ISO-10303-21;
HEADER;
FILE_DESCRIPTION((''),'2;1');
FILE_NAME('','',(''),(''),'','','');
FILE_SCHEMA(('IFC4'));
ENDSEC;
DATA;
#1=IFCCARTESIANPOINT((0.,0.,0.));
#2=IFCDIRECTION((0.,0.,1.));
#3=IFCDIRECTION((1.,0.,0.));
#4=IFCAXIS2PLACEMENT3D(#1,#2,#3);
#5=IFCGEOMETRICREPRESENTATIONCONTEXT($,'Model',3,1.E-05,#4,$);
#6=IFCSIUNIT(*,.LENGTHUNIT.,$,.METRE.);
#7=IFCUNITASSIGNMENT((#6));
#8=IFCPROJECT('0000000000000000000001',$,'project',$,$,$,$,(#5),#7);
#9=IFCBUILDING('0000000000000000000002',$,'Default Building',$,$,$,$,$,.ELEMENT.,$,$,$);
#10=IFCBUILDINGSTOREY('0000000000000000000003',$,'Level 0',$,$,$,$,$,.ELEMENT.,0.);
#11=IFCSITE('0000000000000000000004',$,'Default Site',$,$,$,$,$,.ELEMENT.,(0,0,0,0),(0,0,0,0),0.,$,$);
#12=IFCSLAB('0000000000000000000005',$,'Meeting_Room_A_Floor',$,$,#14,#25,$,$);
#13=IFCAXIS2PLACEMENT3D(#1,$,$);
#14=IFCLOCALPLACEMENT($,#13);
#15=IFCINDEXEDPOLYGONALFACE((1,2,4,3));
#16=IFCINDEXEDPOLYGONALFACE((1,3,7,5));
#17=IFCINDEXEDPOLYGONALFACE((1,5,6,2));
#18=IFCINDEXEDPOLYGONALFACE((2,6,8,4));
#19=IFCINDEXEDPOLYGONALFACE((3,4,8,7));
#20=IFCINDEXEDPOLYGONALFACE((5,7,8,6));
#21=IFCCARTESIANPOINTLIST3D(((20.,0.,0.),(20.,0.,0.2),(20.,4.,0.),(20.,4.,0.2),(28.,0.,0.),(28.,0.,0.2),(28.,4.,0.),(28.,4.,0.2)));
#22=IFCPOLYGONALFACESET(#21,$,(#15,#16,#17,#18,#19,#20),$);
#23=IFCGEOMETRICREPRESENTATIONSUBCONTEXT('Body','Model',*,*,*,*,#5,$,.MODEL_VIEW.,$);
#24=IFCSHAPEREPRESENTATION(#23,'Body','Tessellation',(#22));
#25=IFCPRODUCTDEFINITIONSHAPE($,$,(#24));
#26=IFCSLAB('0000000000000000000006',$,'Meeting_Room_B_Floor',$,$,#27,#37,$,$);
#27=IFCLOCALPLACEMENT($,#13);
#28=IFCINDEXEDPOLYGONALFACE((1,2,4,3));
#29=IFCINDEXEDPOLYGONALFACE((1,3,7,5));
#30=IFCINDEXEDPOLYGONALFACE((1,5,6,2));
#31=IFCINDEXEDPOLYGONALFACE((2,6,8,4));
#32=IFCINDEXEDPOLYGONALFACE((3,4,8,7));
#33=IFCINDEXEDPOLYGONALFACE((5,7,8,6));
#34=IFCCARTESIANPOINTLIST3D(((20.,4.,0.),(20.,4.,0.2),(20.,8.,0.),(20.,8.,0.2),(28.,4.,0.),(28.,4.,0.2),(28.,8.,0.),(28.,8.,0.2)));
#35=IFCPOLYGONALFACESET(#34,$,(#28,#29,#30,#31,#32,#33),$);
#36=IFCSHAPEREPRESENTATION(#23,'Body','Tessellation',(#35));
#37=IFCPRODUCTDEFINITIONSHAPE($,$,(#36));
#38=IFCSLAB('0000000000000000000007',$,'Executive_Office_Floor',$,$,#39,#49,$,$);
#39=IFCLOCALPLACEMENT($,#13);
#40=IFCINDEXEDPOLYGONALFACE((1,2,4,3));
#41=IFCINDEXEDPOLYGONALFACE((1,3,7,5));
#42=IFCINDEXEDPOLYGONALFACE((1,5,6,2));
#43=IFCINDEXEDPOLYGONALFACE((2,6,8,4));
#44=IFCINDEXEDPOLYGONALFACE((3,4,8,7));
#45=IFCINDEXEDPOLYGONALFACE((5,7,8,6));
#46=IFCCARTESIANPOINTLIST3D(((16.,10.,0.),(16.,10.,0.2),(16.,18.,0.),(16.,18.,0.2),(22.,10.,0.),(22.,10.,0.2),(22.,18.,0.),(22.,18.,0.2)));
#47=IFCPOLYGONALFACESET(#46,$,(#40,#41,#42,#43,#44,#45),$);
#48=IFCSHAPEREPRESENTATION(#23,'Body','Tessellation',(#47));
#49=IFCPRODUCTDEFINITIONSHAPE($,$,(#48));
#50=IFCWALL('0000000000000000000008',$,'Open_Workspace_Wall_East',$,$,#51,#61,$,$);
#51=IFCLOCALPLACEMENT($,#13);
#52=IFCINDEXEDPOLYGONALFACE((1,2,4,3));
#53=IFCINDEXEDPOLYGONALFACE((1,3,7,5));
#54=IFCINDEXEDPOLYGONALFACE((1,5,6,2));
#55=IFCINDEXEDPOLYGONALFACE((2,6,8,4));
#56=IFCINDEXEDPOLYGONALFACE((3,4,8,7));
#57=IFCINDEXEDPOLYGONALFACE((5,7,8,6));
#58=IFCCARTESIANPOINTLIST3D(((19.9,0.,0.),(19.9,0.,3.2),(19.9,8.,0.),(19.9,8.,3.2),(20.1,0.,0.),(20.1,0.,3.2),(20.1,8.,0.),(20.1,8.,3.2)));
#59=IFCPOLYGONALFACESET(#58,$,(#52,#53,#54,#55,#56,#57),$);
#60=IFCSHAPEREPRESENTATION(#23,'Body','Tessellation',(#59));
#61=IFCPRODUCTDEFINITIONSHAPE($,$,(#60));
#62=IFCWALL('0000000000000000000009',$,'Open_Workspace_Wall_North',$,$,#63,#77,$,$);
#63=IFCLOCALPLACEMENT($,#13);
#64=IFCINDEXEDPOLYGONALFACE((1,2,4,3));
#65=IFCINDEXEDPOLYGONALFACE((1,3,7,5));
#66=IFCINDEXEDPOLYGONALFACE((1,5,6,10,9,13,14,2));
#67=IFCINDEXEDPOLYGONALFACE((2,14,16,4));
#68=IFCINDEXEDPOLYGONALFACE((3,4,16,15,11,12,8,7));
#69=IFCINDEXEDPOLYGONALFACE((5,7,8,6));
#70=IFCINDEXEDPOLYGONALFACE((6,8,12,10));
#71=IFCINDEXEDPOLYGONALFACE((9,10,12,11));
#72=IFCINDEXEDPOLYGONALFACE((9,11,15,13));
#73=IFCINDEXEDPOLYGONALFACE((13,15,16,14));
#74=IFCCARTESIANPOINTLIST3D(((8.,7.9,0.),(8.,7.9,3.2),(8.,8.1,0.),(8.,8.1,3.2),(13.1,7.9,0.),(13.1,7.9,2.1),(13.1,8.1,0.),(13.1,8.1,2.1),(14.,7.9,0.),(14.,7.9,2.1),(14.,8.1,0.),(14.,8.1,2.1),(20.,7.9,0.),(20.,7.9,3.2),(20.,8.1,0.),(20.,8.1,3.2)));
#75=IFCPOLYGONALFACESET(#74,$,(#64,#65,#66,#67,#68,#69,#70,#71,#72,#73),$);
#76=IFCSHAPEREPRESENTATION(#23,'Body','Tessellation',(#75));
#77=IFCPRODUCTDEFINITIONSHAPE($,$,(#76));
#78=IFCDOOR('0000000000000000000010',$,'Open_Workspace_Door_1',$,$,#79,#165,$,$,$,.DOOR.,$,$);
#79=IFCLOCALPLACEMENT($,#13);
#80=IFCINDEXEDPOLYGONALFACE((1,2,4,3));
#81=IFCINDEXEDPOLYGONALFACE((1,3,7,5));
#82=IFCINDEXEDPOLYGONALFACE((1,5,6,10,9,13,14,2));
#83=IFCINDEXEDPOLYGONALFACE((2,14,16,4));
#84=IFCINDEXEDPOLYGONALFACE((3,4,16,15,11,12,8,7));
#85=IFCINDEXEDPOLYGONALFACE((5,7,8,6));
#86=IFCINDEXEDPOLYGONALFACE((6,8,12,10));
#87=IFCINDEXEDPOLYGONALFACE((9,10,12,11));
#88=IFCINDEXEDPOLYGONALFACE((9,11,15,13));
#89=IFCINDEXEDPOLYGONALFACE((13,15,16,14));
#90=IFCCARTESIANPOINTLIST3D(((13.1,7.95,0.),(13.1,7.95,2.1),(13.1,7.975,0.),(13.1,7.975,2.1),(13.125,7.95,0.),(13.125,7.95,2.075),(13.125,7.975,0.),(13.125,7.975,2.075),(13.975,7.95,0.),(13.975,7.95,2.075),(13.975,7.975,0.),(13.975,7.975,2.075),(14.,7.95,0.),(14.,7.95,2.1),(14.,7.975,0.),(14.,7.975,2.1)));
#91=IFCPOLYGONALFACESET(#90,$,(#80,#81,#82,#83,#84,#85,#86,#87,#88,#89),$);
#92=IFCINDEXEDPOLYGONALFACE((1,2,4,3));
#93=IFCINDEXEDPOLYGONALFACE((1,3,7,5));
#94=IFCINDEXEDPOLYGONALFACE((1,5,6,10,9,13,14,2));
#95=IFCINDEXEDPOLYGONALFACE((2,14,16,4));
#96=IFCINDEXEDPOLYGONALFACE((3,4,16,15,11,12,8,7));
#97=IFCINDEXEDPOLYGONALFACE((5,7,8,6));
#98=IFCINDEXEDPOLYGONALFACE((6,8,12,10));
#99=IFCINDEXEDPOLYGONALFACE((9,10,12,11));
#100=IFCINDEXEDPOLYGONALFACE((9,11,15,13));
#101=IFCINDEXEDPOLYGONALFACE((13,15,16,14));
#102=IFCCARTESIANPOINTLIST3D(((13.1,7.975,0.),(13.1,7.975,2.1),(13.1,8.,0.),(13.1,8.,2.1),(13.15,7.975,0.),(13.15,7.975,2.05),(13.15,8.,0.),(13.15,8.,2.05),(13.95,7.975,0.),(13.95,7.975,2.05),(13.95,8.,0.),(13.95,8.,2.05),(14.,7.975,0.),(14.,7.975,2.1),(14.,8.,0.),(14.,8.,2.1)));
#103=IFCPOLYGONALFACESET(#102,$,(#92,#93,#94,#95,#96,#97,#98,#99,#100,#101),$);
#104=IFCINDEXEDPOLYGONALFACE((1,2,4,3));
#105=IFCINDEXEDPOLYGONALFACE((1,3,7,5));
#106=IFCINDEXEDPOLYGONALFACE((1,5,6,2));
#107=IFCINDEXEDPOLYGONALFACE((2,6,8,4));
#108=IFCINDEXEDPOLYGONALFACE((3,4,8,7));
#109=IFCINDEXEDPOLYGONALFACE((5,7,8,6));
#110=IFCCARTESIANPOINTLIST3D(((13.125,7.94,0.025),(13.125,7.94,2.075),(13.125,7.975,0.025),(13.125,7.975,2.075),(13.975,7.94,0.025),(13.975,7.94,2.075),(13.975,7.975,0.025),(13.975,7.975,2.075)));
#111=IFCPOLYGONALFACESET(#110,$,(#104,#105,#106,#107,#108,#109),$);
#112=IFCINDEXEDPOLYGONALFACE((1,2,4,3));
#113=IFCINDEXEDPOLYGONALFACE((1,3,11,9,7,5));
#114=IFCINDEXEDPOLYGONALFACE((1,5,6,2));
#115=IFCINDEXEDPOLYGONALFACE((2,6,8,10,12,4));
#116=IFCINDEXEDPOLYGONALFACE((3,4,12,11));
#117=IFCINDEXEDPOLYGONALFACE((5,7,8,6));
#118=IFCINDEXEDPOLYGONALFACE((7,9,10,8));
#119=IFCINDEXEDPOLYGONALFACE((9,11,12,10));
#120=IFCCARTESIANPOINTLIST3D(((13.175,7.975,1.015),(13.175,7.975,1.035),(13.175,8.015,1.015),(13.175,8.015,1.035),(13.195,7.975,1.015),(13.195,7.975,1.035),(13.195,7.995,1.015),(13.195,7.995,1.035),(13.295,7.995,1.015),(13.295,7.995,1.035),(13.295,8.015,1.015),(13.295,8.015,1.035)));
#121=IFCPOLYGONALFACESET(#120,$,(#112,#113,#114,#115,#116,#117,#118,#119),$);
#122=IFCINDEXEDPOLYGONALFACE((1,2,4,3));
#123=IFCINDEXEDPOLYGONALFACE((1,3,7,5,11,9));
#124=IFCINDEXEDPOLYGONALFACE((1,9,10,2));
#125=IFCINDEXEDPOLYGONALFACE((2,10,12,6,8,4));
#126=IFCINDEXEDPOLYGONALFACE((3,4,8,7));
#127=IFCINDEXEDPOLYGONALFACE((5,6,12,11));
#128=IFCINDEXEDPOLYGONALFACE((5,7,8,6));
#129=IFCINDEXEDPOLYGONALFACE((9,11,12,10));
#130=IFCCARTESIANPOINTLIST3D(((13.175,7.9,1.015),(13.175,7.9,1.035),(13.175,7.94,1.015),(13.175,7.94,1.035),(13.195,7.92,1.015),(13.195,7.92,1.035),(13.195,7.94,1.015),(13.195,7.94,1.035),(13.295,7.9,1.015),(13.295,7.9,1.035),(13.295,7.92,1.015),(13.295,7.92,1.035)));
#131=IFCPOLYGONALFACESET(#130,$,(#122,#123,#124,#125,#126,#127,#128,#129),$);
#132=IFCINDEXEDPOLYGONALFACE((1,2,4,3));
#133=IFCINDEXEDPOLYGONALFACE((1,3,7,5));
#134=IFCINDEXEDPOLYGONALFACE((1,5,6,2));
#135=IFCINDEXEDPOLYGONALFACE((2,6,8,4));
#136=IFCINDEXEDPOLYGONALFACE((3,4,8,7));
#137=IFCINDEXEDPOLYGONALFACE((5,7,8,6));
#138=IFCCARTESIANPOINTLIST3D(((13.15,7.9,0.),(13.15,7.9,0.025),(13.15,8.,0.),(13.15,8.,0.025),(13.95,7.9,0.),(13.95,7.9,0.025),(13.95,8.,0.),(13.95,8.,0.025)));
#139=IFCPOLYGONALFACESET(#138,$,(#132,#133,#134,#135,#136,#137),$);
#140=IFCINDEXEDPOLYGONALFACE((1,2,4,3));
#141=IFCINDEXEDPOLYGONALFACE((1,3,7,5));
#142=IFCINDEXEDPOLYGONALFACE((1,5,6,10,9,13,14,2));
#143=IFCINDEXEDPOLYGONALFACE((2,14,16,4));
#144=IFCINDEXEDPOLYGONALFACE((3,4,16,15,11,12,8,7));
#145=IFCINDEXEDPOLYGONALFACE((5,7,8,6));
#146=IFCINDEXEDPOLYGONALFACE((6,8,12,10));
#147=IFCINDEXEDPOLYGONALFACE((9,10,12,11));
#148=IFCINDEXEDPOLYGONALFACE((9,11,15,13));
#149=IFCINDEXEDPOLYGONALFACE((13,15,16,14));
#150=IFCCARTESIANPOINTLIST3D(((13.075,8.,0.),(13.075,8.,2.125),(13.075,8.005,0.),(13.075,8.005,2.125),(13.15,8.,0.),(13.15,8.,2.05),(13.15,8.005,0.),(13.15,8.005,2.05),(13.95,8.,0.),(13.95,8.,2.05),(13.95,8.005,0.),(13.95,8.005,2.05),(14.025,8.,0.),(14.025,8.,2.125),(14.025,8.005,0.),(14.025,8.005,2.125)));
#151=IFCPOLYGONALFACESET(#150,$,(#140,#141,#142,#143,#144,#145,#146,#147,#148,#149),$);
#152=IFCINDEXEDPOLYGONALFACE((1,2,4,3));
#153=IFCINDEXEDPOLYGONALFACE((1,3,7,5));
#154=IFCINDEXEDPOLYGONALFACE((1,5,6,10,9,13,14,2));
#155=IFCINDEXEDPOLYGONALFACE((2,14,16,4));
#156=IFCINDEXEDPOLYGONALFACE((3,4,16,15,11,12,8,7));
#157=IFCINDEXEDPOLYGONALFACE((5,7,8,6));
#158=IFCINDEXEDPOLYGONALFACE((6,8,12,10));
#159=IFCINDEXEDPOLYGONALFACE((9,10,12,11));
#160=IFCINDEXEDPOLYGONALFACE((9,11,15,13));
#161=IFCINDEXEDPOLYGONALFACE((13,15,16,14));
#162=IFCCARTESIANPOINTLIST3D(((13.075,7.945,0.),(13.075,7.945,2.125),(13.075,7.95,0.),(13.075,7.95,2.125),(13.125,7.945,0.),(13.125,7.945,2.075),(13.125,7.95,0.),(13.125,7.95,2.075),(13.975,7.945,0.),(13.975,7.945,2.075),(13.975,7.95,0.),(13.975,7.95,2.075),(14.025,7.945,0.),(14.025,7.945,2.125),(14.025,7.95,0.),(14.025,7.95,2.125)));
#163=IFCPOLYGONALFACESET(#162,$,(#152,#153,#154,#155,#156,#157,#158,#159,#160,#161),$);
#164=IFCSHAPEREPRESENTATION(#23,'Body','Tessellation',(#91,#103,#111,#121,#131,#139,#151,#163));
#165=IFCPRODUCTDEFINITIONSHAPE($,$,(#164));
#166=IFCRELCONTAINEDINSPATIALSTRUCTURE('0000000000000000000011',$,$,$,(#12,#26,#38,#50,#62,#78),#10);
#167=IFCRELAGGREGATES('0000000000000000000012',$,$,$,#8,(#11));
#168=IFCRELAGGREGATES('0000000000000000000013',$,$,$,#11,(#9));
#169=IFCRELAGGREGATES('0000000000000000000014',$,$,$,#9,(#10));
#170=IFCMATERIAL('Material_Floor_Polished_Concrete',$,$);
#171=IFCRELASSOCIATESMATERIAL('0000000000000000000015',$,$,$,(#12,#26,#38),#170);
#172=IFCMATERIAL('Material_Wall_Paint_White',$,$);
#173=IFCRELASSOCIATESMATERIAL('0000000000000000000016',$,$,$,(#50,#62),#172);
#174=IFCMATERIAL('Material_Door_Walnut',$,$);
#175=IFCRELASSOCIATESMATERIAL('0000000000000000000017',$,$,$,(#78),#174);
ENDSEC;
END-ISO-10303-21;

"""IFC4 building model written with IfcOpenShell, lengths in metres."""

from ifc_helpers import new_model, si_unit, frame, origin_with_axes, place, context, subcontext, project, spatial, line, indexed_curve, outline, extrude, material, element, fill, save


model = new_model("IFC4")

# Units and contexts
model_context = context("Model", 3, precision=1e-05, world=origin_with_axes())
body_context = subcontext(model_context, "Body", "Model", "MODEL_VIEW")
ifc_project = project(units=[si_unit("LENGTHUNIT", "METRE")], contexts=[model_context])

# Site, building, storey
site = spatial("IfcSite", under=ifc_project, Name="Default Site", CompositionType="ELEMENT", RefLatitude=(0, 0, 0, 0), RefLongitude=(0, 0, 0, 0), RefElevation=0.0)
building = spatial("IfcBuilding", under=site, Name="Default Building", CompositionType="ELEMENT")
storey = spatial("IfcBuildingStorey", under=building, Name="Level 0", CompositionType="ELEMENT", Elevation=0.0)

# Slabs
ifc_material_1 = material(Name="Material_Floor_Polished_Concrete")
for number, where, z_axis, x_axis, name in (
    (1, (20.0, 0.0, 0.0), (0.0, 0.0, 1.0), (1.0, 0.0, 0.0), "Meeting_Room_A_Floor"),
    (2, (20.0, 4.0, 0.0), (0.0, 0.0, 1.0), (1.0, 0.0, 0.0), "Meeting_Room_B_Floor"),
):
    element("IfcSlab", number, at=place(None, frame(where, z_axis=z_axis, x_axis=x_axis)), inside=storey, material=ifc_material_1, Name=name, context=body_context, shape_type="SweptSolid", body=[
        extrude(outline(indexed_curve([(0.0, 0.0), (8.0, 0.0), (8.0, 4.0), (0.0, 4.0)])), None, (0.0, 0.0, 1.0), 0.2),
    ])
slab_placement = place(None, frame((16.0, 10.0, 0.0), z_axis=(0.0, 0.0, 1.0), x_axis=(1.0, 0.0, 0.0)))
element("IfcSlab", 3, at=slab_placement, inside=storey, material=ifc_material_1, Name="Executive_Office_Floor", context=body_context, shape_type="SweptSolid", body=[
    extrude(outline(indexed_curve([(0.0, 0.0), (6.0, 0.0), (6.0, 8.0), (0.0, 8.0)])), None, (0.0, 0.0, 1.0), 0.2),
])

# Wall
ifc_material_2 = material(Name="Material_Wall_Paint_White")
wall_1_placement = place(None, frame((20.0, 0.0, 0.0), z_axis=(0.0, 0.0, 1.0), x_axis=(0.0, 1.0, 0.0)))
element("IfcWall", 4, at=wall_1_placement, inside=storey, material=ifc_material_2, Name="Open_Workspace_Wall_East", context=body_context, shape_type="SweptSolid", body=[
    extrude(outline(indexed_curve([(0.0, 0.0), (0.0, 0.2), (8.0, 0.2), (8.0, 0.0), (0.0, 0.0)], self_intersect=False)), frame((0.0, -0.1, 0.0), z_axis=(0.0, 0.0, 1.0), x_axis=(1.0, 0.0, 0.0)), (0.0, 0.0, 1.0), 3.2),
])

# Wall, opening, door
wall_2_placement = place(None, frame((20.0, 8.0, 0.0), z_axis=(0.0, 0.0, 1.0), x_axis=(-1.0, 0.0, 0.0)))
wall_2 = element("IfcWall", 5, at=wall_2_placement, inside=storey, material=ifc_material_2, Name="Open_Workspace_Wall_North", context=body_context, shape_type="SweptSolid", body=[
    extrude(outline(indexed_curve([(0.0, 0.0), (0.0, 0.2), (12.0, 0.2), (12.0, 0.0), (0.0, 0.0)], self_intersect=False)), frame((0.0, -0.1, 0.0), z_axis=(0.0, 0.0, 1.0), x_axis=(1.0, 0.0, 0.0)), (0.0, 0.0, 1.0), 3.2),
])
opening_1_placement = place(wall_2_placement, frame((6.0, -0.5, 0.0), z_axis=(0.0, 0.0, 1.0), x_axis=(1.0, 0.0, 0.0)))
opening_1 = element("IfcOpeningElement", 6, at=opening_1_placement, inside=storey, cuts=wall_2, PredefinedType="OPENING", context=body_context, shape_type="SweptSolid", body=[
    extrude(outline(indexed_curve([(0.0, 0.0), (0.0, 1.0), (0.9, 1.0), (0.9, 0.0), (0.0, 0.0)], self_intersect=False)), origin_with_axes(), (0.0, 0.0, 1.0), 2.1),
])
ifc_material_3 = material(Name="Material_Door_Walnut")
door_1_placement = place(None, frame((14.0, 8.0, 0.0), z_axis=(0.0, 0.0, 1.0), x_axis=(-1.0, 0.0, 0.0)))
door_1 = element("IfcDoor", 7, at=door_1_placement, inside=storey, material=ifc_material_3, Name="Open_Workspace_Door_1", PredefinedType="DOOR", context=body_context, shape_type="SweptSolid", body=[
    extrude(outline(indexed_curve([(0.0, 0.0), (0.0, 2.1), (0.9, 2.1), (0.9, 0.0), (0.875, 0.0), (0.875, 2.075), (0.025, 2.075), (0.025, 0.0)], segments=[line(1, 2, 3, 4, 5, 6, 7, 8, 1)])), frame((0.0, 0.025, 0.0), z_axis=(0.0, -1.0, 0.0), x_axis=(1.0, 0.0, 0.0)), (0.0, 0.0, -1.0), 0.025),
    extrude(outline(indexed_curve([(0.0, 0.0), (0.0, 2.1), (0.9, 2.1), (0.9, 0.0), (0.85, 0.0), (0.85, 2.05), (0.05, 2.05), (0.05, 0.0)], segments=[line(1, 2, 3, 4, 5, 6, 7, 8, 1)])), frame((0.0, 0.0, 0.0), z_axis=(0.0, -1.0, 0.0), x_axis=(1.0, 0.0, 0.0)), (0.0, 0.0, -1.0), 0.025),
    extrude(outline(indexed_curve([(0.0, 0.0), (0.85, 0.0), (0.85, 0.035), (0.0, 0.035)], segments=[line(1, 2, 3, 4, 1)])), frame((0.025, 0.025, 0.025), z_axis=(0.0, 0.0, 1.0), x_axis=(1.0, 0.0, 0.0)), (0.0, 0.0, 1.0), 2.05),
    extrude(outline(indexed_curve([(0.0, 0.0), (0.0, -0.04), (-0.12, -0.04), (-0.12, -0.02), (-0.02, -0.02), (-0.02, 0.0)], segments=[line(1, 2, 3, 4, 5, 6, 1)])), frame((0.825, 0.025, 1.015), z_axis=(0.0, 0.0, 1.0), x_axis=(1.0, 0.0, 0.0)), (0.0, 0.0, 1.0), 0.02),
    extrude(outline(indexed_curve([(0.0, 0.0), (0.0, 0.04), (-0.12, 0.04), (-0.12, 0.02), (-0.02, 0.02), (-0.02, 0.0)], segments=[line(1, 2, 3, 4, 5, 6, 1)])), frame((0.825, 0.06, 1.015), z_axis=(0.0, 0.0, 1.0), x_axis=(1.0, 0.0, 0.0)), (0.0, 0.0, 1.0), 0.02),
    extrude(outline(indexed_curve([(0.0, 0.0), (0.8, 0.0), (0.8, 0.1), (0.0, 0.1)], segments=[line(1, 2, 3, 4, 1)])), frame((0.05, 0.0, 0.0), z_axis=(0.0, 0.0, 1.0), x_axis=(1.0, 0.0, 0.0)), (0.0, 0.0, 1.0), 0.025),
    extrude(outline(indexed_curve([(0.0, 0.0), (0.0, 2.125), (0.95, 2.125), (0.95, 0.0), (0.875, 0.0), (0.875, 2.05), (0.075, 2.05), (0.075, 0.0)], segments=[line(1, 2, 3, 4, 5, 6, 7, 8, 1)])), frame((-0.025, -0.005, 0.0), z_axis=(0.0, -1.0, 0.0), x_axis=(1.0, 0.0, 0.0)), (0.0, 0.0, -1.0), 0.005),
    extrude(outline(indexed_curve([(0.0, 0.0), (0.0, 2.125), (0.95, 2.125), (0.95, 0.0), (0.9, 0.0), (0.9, 2.075), (0.05, 2.075), (0.05, 0.0)], segments=[line(1, 2, 3, 4, 5, 6, 7, 8, 1)])), frame((-0.025, 0.05, 0.0), z_axis=(0.0, -1.0, 0.0), x_axis=(1.0, 0.0, 0.0)), (0.0, 0.0, -1.0), 0.005),
])
fill(opening_1, door_1)

save(model, "model.ifc")
